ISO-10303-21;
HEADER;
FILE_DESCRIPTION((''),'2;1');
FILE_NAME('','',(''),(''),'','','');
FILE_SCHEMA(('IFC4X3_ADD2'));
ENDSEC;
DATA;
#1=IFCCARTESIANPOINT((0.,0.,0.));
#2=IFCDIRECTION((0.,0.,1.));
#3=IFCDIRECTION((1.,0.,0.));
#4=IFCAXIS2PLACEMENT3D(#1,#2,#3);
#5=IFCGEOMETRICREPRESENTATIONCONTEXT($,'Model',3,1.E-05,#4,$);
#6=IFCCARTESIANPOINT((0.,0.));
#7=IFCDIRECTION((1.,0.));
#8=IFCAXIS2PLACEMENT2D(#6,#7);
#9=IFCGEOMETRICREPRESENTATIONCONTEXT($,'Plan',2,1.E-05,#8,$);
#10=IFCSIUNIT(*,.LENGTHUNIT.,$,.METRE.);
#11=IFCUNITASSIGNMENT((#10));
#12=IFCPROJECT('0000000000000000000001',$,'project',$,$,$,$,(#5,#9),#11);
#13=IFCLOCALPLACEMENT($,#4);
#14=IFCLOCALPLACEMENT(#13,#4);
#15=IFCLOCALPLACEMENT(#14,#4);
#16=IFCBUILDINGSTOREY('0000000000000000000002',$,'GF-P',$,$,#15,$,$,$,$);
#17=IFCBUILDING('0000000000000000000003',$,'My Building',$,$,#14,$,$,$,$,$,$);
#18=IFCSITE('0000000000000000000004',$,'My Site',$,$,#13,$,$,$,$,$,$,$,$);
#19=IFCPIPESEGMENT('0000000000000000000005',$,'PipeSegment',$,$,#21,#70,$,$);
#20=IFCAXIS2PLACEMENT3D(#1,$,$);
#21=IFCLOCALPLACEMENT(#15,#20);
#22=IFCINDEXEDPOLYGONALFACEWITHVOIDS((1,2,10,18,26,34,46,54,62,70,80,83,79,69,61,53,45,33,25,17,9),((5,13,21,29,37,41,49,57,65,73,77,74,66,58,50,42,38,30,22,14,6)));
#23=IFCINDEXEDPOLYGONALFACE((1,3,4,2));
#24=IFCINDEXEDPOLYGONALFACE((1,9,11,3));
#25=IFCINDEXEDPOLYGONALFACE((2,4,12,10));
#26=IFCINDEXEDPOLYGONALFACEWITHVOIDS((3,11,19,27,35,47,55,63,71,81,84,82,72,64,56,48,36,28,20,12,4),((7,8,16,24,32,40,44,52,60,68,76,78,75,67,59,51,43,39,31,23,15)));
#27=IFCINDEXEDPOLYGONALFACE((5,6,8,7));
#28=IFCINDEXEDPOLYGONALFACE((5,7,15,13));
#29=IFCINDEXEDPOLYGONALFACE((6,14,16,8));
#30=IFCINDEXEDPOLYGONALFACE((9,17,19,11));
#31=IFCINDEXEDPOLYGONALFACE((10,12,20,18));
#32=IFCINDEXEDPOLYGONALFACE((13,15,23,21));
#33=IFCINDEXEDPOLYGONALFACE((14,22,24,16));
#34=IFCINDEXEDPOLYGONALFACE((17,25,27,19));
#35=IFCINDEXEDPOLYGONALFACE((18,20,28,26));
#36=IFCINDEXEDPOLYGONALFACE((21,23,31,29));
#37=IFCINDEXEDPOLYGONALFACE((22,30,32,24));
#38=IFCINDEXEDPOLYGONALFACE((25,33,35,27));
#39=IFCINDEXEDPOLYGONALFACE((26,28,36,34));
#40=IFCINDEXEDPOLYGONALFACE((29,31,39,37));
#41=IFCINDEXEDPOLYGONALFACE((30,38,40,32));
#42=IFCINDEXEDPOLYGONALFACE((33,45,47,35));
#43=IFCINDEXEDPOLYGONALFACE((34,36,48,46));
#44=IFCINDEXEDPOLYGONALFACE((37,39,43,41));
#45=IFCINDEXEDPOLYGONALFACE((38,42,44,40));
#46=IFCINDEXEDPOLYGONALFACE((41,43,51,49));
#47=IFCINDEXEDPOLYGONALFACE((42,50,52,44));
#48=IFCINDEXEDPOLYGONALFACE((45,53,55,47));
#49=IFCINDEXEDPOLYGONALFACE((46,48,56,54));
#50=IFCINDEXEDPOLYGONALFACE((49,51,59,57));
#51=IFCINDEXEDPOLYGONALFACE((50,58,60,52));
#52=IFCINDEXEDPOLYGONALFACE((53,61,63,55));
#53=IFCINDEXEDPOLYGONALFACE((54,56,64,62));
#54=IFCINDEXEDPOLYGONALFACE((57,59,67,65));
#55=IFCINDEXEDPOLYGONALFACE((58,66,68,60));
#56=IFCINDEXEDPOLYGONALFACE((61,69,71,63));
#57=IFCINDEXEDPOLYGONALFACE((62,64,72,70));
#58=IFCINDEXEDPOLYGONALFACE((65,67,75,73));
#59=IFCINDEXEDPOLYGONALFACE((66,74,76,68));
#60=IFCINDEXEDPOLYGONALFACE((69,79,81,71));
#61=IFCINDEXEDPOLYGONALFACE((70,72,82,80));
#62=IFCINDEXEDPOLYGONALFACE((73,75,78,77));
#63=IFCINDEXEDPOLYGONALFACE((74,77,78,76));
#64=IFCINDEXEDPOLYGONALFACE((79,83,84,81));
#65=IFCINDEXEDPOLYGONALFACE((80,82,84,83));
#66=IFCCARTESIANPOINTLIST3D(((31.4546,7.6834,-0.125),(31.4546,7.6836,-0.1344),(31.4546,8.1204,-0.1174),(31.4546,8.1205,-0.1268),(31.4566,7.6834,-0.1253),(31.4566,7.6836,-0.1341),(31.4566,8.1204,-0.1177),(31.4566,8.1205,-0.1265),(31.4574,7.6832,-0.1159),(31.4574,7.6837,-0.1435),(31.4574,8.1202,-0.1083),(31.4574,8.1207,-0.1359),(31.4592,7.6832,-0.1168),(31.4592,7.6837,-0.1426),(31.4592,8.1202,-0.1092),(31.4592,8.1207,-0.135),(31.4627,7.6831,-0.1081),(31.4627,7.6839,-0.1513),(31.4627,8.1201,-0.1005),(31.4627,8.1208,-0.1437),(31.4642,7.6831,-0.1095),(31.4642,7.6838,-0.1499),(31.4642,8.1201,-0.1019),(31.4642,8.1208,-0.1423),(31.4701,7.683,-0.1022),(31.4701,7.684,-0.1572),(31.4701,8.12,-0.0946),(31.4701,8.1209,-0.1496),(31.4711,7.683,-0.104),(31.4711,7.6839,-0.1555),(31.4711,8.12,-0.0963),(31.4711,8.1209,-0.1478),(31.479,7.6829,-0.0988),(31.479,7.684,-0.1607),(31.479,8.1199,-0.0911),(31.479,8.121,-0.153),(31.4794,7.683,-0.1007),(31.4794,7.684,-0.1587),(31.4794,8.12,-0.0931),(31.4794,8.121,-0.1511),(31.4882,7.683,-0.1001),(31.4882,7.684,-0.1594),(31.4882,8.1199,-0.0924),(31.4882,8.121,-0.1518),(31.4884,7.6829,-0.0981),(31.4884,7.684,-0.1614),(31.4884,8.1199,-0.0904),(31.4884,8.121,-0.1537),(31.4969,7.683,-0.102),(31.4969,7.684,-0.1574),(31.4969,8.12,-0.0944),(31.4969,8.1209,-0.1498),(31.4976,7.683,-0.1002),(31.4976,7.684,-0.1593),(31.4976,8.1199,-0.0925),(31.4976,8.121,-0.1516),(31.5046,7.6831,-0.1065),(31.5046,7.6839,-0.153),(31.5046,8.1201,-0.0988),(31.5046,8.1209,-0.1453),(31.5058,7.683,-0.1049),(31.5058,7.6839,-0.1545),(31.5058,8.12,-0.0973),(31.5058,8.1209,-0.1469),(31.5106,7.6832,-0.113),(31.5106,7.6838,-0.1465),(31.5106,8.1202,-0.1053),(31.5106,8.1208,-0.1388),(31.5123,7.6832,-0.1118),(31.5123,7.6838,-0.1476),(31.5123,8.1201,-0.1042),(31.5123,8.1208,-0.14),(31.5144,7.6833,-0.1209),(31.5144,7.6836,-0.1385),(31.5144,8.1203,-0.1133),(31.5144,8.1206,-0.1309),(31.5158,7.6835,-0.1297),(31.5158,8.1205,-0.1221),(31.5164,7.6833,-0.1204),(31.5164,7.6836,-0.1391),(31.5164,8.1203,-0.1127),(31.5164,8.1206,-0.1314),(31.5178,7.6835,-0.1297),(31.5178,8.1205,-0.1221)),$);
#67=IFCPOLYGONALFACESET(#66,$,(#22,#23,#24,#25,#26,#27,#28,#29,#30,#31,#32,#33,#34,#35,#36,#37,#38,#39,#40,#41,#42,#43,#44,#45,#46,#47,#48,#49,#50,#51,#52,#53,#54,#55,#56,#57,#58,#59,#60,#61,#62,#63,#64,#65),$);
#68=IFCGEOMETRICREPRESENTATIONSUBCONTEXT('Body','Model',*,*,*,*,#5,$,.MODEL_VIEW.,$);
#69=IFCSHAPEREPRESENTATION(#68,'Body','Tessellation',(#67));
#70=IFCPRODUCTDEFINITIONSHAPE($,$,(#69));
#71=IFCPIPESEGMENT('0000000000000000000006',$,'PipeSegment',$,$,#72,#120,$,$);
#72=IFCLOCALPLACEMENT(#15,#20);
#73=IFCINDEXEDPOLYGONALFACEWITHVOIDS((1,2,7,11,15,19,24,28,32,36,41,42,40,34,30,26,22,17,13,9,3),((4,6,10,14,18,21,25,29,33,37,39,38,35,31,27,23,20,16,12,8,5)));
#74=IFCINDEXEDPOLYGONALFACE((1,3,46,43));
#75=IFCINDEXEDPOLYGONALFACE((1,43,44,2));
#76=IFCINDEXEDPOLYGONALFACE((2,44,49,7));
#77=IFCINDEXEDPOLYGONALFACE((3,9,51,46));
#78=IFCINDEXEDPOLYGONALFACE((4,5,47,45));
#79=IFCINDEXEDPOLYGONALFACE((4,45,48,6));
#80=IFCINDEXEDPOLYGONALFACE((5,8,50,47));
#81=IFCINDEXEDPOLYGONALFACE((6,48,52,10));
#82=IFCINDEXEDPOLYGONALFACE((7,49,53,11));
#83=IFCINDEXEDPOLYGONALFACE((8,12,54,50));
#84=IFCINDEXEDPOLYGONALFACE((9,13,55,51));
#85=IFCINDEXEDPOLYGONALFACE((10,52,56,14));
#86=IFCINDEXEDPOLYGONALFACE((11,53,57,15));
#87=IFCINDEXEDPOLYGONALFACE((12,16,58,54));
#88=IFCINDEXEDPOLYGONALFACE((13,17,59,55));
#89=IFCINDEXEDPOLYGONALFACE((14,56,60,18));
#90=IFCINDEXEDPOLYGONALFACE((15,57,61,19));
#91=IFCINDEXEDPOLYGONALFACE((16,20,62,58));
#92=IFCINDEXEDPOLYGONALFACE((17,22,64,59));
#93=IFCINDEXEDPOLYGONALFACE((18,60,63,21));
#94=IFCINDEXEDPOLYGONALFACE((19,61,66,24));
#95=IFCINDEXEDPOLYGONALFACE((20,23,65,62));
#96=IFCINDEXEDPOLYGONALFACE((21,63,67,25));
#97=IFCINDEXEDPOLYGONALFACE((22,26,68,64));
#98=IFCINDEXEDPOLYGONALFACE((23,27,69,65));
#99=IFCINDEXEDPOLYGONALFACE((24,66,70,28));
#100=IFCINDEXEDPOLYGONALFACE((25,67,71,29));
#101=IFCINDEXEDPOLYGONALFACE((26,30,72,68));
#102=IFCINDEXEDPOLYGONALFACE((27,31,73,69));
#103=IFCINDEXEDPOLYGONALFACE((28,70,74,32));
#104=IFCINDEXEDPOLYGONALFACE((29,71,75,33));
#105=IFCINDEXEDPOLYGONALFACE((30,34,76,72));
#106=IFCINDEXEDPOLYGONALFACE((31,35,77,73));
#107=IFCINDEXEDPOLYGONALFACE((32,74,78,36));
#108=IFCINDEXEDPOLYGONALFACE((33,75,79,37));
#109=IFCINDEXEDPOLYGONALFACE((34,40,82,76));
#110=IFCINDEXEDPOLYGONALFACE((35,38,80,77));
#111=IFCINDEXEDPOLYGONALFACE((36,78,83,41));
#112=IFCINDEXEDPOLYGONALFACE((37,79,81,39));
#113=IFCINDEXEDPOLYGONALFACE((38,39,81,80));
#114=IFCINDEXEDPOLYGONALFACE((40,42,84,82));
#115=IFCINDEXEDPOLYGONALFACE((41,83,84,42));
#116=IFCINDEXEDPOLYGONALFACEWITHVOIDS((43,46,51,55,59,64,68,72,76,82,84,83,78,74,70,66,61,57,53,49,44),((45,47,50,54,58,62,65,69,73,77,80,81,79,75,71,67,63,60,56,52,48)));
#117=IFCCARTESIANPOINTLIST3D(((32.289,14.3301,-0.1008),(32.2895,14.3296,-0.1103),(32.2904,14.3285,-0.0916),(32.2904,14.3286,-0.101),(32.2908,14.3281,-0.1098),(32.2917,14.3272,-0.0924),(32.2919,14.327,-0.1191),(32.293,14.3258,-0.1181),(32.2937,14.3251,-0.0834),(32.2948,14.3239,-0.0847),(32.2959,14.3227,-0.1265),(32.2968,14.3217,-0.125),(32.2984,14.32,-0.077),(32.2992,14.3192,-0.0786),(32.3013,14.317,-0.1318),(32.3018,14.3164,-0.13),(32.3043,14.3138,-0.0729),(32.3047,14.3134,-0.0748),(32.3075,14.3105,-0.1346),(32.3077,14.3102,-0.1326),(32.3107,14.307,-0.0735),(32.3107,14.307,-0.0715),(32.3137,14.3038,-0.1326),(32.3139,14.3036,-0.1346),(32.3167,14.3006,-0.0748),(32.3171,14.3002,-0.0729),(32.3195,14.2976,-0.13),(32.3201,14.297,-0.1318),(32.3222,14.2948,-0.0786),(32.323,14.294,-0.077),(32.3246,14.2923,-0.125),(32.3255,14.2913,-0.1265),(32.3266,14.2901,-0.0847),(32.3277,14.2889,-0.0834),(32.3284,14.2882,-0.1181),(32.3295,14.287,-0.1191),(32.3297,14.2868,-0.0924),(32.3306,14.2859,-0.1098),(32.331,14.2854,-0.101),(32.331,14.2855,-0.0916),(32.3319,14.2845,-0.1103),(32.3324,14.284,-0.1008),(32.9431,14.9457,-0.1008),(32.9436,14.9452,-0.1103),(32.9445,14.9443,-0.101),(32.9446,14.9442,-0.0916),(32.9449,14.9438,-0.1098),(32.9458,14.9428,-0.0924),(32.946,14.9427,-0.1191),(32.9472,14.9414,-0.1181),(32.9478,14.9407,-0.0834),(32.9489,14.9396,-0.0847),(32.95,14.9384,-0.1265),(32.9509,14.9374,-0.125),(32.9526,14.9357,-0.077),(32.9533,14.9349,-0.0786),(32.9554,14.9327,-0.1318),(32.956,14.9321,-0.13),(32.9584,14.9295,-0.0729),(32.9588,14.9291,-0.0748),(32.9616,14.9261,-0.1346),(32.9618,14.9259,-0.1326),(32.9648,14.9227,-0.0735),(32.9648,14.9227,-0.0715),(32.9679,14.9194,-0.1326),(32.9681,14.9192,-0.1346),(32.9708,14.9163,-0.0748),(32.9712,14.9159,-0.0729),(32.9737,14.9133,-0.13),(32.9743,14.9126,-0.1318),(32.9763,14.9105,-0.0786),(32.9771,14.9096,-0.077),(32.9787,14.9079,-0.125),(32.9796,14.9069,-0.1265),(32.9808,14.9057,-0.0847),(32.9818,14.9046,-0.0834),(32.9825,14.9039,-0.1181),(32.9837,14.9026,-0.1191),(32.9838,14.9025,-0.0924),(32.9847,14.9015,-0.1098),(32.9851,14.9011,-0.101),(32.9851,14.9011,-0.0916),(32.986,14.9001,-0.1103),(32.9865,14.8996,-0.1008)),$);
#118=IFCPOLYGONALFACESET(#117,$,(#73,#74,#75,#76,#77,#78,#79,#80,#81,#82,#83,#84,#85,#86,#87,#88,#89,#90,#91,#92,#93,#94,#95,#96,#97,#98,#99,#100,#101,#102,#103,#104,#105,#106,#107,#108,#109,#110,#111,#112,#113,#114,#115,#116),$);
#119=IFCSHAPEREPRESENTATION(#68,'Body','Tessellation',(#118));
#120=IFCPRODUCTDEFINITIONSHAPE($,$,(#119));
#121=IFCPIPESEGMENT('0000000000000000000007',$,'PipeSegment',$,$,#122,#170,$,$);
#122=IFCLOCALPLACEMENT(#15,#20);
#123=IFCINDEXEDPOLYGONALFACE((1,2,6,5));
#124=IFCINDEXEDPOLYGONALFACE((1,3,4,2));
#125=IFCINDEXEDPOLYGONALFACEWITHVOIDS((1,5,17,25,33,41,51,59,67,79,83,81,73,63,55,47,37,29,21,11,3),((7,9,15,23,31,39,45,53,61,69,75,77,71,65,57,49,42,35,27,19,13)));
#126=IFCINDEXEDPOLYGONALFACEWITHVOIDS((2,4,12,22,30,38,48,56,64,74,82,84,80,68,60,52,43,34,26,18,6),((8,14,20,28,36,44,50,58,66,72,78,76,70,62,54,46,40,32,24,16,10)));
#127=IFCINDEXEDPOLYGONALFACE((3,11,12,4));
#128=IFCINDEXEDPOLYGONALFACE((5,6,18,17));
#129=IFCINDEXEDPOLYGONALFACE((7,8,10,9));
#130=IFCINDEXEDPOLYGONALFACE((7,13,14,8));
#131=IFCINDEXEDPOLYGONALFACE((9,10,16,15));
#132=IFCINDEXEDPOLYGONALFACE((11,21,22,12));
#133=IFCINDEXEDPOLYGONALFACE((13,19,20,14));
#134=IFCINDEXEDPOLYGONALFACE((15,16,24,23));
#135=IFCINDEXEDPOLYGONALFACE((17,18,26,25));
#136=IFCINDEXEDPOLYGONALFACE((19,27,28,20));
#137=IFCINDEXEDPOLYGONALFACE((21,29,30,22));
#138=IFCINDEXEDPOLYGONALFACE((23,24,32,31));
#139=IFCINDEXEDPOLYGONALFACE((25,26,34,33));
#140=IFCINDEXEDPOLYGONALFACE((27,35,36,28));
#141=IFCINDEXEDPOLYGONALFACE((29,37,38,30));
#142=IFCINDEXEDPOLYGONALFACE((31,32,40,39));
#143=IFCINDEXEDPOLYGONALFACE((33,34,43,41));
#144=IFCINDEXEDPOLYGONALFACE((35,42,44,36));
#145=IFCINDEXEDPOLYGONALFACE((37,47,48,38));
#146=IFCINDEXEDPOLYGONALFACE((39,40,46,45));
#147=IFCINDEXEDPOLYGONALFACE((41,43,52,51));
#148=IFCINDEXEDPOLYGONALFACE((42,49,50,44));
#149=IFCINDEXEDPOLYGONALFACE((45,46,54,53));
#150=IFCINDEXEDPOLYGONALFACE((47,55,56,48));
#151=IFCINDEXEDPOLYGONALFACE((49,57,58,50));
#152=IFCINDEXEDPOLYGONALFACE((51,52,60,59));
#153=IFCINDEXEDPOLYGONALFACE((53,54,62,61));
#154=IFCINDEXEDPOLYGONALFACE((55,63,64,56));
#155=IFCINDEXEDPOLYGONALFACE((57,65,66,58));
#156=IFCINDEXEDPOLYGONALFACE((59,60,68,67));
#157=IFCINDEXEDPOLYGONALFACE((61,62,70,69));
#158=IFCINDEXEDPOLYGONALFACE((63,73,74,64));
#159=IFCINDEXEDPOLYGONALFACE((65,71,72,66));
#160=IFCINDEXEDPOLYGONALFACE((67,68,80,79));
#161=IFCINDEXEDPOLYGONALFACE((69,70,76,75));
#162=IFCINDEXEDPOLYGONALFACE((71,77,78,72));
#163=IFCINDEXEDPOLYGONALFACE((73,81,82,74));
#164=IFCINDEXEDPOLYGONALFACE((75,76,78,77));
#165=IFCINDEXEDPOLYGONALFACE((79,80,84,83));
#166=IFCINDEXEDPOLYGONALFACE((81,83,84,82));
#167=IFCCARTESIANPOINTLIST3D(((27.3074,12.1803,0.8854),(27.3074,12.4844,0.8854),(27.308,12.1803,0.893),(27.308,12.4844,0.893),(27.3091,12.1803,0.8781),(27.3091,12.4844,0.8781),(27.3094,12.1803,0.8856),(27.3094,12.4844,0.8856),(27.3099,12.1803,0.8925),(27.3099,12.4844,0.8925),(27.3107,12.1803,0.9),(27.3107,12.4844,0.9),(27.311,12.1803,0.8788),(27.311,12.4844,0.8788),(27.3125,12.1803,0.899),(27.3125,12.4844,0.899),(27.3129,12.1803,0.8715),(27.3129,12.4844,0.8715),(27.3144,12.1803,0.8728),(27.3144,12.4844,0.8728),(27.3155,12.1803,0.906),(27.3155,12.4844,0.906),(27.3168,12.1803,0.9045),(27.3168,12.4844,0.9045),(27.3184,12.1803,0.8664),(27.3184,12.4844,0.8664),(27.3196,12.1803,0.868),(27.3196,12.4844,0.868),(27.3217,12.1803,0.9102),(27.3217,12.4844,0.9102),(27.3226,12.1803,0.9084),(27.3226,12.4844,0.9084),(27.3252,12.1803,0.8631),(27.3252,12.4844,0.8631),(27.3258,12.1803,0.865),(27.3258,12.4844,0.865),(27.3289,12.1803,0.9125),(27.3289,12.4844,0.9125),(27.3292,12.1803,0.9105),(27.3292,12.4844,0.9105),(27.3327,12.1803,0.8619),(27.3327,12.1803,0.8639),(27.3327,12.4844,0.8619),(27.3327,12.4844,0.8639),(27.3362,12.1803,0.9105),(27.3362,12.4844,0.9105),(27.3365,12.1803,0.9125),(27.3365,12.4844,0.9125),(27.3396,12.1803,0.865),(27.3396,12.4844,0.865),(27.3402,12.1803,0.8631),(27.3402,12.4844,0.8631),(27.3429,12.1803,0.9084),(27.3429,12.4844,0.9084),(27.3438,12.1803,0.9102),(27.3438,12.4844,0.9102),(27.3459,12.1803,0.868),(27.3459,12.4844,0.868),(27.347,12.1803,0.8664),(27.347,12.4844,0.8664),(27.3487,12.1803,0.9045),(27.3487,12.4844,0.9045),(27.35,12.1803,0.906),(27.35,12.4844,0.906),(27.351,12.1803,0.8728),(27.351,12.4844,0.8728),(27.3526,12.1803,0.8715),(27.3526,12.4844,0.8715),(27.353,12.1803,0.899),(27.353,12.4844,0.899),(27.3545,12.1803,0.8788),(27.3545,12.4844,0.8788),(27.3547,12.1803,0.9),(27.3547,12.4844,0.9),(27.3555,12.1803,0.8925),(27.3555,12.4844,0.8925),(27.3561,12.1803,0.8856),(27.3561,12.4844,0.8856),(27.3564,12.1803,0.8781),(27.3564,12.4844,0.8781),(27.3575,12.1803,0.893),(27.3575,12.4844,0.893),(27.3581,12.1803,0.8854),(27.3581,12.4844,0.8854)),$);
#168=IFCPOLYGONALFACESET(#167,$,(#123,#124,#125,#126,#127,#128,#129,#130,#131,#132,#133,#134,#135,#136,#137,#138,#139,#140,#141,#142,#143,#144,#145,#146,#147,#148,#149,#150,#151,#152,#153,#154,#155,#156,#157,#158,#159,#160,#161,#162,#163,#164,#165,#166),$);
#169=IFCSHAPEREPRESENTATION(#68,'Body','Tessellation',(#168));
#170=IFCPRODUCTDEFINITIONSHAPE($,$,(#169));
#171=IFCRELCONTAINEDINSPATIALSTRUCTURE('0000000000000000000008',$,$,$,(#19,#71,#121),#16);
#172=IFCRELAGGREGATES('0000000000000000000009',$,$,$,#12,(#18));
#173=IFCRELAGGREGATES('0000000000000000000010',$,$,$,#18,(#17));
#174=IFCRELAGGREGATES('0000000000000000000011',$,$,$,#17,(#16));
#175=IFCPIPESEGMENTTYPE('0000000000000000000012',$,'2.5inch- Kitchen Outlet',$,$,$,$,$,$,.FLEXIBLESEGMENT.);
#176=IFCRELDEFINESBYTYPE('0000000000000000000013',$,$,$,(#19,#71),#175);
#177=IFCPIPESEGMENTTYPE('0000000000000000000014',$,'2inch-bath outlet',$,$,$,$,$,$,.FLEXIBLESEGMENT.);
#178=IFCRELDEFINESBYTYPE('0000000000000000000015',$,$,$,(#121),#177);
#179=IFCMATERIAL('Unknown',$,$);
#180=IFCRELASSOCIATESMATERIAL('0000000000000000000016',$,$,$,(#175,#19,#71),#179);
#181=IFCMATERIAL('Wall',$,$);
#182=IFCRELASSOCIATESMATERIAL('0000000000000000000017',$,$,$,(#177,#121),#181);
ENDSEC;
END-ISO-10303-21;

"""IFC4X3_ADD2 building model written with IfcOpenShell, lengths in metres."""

from ifc_helpers import new_model, si_unit, frame, origin_with_axes, origin_2d_with_axis, place, context, subcontext, project, spatial, hollow_circle, extrude, material, material_profile, profile_set, profile_usage, type_object, element, save


model = new_model("IFC4X3_ADD2")

# Units and contexts
model_context = context("Model", 3, precision=1e-05, world=origin_with_axes())
plan_context = context("Plan", 2, precision=1e-05, world=origin_2d_with_axis())
body_context = subcontext(model_context, "Body", "Model", "MODEL_VIEW")
ifc_project = project(units=[si_unit("LENGTHUNIT", "METRE")], contexts=[model_context, plan_context])

# Site, building, storey
site_placement = place(None, origin_with_axes())
site = spatial("IfcSite", under=ifc_project, at=site_placement, Name="My Site")
building_placement = place(site_placement, origin_with_axes())
building = spatial("IfcBuilding", under=site, at=building_placement, Name="My Building")
storey_placement = place(building_placement, origin_with_axes())
storey = spatial("IfcBuildingStorey", under=building, at=storey_placement, Name="GF-P")

# Pipe segments
ifc_material_1 = material(Name="Unknown")
ifc_material_profile_1 = material_profile(ifc_material_1, hollow_circle(Radius=0.0318, WallThickness=0.002))
ifc_profile_set_1 = profile_set([ifc_material_profile_1], Name="kitchenwater")
pipe_segment_type_1 = type_object("IfcPipeSegmentType", Name="2.5inch- Kitchen Outlet", PredefinedType="FLEXIBLESEGMENT", material=ifc_profile_set_1)
ifc_profile_usage_1 = profile_usage(ifc_profile_set_1)
pipe_segment_1_placement = place(storey_placement, frame((31.486, 8.1205, -0.1221), z_axis=(0.0, -0.999848, -0.017452), x_axis=(1.0, 0.0, 0.0)))
element("IfcPipeSegment", 1, at=pipe_segment_1_placement, inside=storey, type_object=pipe_segment_type_1, material=ifc_profile_usage_1, Name="PipeSegment", context=body_context, shape_type="SweptSolid", body=[
    extrude(hollow_circle(Radius=0.0318, WallThickness=0.002), origin_with_axes(), (0.0, 0.0, 1.0), 0.4371),
])
ifc_profile_usage_2 = profile_usage(ifc_profile_set_1)
pipe_segment_2_placement = place(storey_placement, frame((32.3107, 14.307, -0.1032), z_axis=(0.728191, 0.685374, 0.0), x_axis=(0.000001, 0.0, 1.0)))
element("IfcPipeSegment", 2, at=pipe_segment_2_placement, inside=storey, type_object=pipe_segment_type_1, material=ifc_profile_usage_2, Name="PipeSegment", context=body_context, shape_type="SweptSolid", body=[
    extrude(hollow_circle(Radius=0.0318, WallThickness=0.002), origin_with_axes(), (0.0, 0.0, 1.0), 0.8983),
])
ifc_material_2 = material(Name="Wall")
ifc_material_profile_2 = material_profile(ifc_material_2, hollow_circle(Radius=0.0254, WallThickness=0.002))
ifc_profile_set_2 = profile_set([ifc_material_profile_2], Name="graywater")
ifc_profile_usage_3 = profile_usage(ifc_profile_set_2, cardinal=5)
pipe_segment_type_2 = type_object("IfcPipeSegmentType", Name="2inch-bath outlet", PredefinedType="FLEXIBLESEGMENT", material=ifc_profile_set_2)
pipe_segment_3_placement = place(storey_placement, frame((27.3327, 12.1803, 0.8873), z_axis=(0.0, 1.0, 0.0), x_axis=(0.0, 0.0, -1.0)))
element("IfcPipeSegment", 3, at=pipe_segment_3_placement, inside=storey, type_object=pipe_segment_type_2, material=ifc_profile_usage_3, Name="PipeSegment", context=body_context, shape_type="SweptSolid", body=[
    extrude(hollow_circle(Radius=0.0254, WallThickness=0.002), origin_with_axes(), (0.0, 0.0, 1.0), 0.3041),
])

save(model, "model.ifc")
